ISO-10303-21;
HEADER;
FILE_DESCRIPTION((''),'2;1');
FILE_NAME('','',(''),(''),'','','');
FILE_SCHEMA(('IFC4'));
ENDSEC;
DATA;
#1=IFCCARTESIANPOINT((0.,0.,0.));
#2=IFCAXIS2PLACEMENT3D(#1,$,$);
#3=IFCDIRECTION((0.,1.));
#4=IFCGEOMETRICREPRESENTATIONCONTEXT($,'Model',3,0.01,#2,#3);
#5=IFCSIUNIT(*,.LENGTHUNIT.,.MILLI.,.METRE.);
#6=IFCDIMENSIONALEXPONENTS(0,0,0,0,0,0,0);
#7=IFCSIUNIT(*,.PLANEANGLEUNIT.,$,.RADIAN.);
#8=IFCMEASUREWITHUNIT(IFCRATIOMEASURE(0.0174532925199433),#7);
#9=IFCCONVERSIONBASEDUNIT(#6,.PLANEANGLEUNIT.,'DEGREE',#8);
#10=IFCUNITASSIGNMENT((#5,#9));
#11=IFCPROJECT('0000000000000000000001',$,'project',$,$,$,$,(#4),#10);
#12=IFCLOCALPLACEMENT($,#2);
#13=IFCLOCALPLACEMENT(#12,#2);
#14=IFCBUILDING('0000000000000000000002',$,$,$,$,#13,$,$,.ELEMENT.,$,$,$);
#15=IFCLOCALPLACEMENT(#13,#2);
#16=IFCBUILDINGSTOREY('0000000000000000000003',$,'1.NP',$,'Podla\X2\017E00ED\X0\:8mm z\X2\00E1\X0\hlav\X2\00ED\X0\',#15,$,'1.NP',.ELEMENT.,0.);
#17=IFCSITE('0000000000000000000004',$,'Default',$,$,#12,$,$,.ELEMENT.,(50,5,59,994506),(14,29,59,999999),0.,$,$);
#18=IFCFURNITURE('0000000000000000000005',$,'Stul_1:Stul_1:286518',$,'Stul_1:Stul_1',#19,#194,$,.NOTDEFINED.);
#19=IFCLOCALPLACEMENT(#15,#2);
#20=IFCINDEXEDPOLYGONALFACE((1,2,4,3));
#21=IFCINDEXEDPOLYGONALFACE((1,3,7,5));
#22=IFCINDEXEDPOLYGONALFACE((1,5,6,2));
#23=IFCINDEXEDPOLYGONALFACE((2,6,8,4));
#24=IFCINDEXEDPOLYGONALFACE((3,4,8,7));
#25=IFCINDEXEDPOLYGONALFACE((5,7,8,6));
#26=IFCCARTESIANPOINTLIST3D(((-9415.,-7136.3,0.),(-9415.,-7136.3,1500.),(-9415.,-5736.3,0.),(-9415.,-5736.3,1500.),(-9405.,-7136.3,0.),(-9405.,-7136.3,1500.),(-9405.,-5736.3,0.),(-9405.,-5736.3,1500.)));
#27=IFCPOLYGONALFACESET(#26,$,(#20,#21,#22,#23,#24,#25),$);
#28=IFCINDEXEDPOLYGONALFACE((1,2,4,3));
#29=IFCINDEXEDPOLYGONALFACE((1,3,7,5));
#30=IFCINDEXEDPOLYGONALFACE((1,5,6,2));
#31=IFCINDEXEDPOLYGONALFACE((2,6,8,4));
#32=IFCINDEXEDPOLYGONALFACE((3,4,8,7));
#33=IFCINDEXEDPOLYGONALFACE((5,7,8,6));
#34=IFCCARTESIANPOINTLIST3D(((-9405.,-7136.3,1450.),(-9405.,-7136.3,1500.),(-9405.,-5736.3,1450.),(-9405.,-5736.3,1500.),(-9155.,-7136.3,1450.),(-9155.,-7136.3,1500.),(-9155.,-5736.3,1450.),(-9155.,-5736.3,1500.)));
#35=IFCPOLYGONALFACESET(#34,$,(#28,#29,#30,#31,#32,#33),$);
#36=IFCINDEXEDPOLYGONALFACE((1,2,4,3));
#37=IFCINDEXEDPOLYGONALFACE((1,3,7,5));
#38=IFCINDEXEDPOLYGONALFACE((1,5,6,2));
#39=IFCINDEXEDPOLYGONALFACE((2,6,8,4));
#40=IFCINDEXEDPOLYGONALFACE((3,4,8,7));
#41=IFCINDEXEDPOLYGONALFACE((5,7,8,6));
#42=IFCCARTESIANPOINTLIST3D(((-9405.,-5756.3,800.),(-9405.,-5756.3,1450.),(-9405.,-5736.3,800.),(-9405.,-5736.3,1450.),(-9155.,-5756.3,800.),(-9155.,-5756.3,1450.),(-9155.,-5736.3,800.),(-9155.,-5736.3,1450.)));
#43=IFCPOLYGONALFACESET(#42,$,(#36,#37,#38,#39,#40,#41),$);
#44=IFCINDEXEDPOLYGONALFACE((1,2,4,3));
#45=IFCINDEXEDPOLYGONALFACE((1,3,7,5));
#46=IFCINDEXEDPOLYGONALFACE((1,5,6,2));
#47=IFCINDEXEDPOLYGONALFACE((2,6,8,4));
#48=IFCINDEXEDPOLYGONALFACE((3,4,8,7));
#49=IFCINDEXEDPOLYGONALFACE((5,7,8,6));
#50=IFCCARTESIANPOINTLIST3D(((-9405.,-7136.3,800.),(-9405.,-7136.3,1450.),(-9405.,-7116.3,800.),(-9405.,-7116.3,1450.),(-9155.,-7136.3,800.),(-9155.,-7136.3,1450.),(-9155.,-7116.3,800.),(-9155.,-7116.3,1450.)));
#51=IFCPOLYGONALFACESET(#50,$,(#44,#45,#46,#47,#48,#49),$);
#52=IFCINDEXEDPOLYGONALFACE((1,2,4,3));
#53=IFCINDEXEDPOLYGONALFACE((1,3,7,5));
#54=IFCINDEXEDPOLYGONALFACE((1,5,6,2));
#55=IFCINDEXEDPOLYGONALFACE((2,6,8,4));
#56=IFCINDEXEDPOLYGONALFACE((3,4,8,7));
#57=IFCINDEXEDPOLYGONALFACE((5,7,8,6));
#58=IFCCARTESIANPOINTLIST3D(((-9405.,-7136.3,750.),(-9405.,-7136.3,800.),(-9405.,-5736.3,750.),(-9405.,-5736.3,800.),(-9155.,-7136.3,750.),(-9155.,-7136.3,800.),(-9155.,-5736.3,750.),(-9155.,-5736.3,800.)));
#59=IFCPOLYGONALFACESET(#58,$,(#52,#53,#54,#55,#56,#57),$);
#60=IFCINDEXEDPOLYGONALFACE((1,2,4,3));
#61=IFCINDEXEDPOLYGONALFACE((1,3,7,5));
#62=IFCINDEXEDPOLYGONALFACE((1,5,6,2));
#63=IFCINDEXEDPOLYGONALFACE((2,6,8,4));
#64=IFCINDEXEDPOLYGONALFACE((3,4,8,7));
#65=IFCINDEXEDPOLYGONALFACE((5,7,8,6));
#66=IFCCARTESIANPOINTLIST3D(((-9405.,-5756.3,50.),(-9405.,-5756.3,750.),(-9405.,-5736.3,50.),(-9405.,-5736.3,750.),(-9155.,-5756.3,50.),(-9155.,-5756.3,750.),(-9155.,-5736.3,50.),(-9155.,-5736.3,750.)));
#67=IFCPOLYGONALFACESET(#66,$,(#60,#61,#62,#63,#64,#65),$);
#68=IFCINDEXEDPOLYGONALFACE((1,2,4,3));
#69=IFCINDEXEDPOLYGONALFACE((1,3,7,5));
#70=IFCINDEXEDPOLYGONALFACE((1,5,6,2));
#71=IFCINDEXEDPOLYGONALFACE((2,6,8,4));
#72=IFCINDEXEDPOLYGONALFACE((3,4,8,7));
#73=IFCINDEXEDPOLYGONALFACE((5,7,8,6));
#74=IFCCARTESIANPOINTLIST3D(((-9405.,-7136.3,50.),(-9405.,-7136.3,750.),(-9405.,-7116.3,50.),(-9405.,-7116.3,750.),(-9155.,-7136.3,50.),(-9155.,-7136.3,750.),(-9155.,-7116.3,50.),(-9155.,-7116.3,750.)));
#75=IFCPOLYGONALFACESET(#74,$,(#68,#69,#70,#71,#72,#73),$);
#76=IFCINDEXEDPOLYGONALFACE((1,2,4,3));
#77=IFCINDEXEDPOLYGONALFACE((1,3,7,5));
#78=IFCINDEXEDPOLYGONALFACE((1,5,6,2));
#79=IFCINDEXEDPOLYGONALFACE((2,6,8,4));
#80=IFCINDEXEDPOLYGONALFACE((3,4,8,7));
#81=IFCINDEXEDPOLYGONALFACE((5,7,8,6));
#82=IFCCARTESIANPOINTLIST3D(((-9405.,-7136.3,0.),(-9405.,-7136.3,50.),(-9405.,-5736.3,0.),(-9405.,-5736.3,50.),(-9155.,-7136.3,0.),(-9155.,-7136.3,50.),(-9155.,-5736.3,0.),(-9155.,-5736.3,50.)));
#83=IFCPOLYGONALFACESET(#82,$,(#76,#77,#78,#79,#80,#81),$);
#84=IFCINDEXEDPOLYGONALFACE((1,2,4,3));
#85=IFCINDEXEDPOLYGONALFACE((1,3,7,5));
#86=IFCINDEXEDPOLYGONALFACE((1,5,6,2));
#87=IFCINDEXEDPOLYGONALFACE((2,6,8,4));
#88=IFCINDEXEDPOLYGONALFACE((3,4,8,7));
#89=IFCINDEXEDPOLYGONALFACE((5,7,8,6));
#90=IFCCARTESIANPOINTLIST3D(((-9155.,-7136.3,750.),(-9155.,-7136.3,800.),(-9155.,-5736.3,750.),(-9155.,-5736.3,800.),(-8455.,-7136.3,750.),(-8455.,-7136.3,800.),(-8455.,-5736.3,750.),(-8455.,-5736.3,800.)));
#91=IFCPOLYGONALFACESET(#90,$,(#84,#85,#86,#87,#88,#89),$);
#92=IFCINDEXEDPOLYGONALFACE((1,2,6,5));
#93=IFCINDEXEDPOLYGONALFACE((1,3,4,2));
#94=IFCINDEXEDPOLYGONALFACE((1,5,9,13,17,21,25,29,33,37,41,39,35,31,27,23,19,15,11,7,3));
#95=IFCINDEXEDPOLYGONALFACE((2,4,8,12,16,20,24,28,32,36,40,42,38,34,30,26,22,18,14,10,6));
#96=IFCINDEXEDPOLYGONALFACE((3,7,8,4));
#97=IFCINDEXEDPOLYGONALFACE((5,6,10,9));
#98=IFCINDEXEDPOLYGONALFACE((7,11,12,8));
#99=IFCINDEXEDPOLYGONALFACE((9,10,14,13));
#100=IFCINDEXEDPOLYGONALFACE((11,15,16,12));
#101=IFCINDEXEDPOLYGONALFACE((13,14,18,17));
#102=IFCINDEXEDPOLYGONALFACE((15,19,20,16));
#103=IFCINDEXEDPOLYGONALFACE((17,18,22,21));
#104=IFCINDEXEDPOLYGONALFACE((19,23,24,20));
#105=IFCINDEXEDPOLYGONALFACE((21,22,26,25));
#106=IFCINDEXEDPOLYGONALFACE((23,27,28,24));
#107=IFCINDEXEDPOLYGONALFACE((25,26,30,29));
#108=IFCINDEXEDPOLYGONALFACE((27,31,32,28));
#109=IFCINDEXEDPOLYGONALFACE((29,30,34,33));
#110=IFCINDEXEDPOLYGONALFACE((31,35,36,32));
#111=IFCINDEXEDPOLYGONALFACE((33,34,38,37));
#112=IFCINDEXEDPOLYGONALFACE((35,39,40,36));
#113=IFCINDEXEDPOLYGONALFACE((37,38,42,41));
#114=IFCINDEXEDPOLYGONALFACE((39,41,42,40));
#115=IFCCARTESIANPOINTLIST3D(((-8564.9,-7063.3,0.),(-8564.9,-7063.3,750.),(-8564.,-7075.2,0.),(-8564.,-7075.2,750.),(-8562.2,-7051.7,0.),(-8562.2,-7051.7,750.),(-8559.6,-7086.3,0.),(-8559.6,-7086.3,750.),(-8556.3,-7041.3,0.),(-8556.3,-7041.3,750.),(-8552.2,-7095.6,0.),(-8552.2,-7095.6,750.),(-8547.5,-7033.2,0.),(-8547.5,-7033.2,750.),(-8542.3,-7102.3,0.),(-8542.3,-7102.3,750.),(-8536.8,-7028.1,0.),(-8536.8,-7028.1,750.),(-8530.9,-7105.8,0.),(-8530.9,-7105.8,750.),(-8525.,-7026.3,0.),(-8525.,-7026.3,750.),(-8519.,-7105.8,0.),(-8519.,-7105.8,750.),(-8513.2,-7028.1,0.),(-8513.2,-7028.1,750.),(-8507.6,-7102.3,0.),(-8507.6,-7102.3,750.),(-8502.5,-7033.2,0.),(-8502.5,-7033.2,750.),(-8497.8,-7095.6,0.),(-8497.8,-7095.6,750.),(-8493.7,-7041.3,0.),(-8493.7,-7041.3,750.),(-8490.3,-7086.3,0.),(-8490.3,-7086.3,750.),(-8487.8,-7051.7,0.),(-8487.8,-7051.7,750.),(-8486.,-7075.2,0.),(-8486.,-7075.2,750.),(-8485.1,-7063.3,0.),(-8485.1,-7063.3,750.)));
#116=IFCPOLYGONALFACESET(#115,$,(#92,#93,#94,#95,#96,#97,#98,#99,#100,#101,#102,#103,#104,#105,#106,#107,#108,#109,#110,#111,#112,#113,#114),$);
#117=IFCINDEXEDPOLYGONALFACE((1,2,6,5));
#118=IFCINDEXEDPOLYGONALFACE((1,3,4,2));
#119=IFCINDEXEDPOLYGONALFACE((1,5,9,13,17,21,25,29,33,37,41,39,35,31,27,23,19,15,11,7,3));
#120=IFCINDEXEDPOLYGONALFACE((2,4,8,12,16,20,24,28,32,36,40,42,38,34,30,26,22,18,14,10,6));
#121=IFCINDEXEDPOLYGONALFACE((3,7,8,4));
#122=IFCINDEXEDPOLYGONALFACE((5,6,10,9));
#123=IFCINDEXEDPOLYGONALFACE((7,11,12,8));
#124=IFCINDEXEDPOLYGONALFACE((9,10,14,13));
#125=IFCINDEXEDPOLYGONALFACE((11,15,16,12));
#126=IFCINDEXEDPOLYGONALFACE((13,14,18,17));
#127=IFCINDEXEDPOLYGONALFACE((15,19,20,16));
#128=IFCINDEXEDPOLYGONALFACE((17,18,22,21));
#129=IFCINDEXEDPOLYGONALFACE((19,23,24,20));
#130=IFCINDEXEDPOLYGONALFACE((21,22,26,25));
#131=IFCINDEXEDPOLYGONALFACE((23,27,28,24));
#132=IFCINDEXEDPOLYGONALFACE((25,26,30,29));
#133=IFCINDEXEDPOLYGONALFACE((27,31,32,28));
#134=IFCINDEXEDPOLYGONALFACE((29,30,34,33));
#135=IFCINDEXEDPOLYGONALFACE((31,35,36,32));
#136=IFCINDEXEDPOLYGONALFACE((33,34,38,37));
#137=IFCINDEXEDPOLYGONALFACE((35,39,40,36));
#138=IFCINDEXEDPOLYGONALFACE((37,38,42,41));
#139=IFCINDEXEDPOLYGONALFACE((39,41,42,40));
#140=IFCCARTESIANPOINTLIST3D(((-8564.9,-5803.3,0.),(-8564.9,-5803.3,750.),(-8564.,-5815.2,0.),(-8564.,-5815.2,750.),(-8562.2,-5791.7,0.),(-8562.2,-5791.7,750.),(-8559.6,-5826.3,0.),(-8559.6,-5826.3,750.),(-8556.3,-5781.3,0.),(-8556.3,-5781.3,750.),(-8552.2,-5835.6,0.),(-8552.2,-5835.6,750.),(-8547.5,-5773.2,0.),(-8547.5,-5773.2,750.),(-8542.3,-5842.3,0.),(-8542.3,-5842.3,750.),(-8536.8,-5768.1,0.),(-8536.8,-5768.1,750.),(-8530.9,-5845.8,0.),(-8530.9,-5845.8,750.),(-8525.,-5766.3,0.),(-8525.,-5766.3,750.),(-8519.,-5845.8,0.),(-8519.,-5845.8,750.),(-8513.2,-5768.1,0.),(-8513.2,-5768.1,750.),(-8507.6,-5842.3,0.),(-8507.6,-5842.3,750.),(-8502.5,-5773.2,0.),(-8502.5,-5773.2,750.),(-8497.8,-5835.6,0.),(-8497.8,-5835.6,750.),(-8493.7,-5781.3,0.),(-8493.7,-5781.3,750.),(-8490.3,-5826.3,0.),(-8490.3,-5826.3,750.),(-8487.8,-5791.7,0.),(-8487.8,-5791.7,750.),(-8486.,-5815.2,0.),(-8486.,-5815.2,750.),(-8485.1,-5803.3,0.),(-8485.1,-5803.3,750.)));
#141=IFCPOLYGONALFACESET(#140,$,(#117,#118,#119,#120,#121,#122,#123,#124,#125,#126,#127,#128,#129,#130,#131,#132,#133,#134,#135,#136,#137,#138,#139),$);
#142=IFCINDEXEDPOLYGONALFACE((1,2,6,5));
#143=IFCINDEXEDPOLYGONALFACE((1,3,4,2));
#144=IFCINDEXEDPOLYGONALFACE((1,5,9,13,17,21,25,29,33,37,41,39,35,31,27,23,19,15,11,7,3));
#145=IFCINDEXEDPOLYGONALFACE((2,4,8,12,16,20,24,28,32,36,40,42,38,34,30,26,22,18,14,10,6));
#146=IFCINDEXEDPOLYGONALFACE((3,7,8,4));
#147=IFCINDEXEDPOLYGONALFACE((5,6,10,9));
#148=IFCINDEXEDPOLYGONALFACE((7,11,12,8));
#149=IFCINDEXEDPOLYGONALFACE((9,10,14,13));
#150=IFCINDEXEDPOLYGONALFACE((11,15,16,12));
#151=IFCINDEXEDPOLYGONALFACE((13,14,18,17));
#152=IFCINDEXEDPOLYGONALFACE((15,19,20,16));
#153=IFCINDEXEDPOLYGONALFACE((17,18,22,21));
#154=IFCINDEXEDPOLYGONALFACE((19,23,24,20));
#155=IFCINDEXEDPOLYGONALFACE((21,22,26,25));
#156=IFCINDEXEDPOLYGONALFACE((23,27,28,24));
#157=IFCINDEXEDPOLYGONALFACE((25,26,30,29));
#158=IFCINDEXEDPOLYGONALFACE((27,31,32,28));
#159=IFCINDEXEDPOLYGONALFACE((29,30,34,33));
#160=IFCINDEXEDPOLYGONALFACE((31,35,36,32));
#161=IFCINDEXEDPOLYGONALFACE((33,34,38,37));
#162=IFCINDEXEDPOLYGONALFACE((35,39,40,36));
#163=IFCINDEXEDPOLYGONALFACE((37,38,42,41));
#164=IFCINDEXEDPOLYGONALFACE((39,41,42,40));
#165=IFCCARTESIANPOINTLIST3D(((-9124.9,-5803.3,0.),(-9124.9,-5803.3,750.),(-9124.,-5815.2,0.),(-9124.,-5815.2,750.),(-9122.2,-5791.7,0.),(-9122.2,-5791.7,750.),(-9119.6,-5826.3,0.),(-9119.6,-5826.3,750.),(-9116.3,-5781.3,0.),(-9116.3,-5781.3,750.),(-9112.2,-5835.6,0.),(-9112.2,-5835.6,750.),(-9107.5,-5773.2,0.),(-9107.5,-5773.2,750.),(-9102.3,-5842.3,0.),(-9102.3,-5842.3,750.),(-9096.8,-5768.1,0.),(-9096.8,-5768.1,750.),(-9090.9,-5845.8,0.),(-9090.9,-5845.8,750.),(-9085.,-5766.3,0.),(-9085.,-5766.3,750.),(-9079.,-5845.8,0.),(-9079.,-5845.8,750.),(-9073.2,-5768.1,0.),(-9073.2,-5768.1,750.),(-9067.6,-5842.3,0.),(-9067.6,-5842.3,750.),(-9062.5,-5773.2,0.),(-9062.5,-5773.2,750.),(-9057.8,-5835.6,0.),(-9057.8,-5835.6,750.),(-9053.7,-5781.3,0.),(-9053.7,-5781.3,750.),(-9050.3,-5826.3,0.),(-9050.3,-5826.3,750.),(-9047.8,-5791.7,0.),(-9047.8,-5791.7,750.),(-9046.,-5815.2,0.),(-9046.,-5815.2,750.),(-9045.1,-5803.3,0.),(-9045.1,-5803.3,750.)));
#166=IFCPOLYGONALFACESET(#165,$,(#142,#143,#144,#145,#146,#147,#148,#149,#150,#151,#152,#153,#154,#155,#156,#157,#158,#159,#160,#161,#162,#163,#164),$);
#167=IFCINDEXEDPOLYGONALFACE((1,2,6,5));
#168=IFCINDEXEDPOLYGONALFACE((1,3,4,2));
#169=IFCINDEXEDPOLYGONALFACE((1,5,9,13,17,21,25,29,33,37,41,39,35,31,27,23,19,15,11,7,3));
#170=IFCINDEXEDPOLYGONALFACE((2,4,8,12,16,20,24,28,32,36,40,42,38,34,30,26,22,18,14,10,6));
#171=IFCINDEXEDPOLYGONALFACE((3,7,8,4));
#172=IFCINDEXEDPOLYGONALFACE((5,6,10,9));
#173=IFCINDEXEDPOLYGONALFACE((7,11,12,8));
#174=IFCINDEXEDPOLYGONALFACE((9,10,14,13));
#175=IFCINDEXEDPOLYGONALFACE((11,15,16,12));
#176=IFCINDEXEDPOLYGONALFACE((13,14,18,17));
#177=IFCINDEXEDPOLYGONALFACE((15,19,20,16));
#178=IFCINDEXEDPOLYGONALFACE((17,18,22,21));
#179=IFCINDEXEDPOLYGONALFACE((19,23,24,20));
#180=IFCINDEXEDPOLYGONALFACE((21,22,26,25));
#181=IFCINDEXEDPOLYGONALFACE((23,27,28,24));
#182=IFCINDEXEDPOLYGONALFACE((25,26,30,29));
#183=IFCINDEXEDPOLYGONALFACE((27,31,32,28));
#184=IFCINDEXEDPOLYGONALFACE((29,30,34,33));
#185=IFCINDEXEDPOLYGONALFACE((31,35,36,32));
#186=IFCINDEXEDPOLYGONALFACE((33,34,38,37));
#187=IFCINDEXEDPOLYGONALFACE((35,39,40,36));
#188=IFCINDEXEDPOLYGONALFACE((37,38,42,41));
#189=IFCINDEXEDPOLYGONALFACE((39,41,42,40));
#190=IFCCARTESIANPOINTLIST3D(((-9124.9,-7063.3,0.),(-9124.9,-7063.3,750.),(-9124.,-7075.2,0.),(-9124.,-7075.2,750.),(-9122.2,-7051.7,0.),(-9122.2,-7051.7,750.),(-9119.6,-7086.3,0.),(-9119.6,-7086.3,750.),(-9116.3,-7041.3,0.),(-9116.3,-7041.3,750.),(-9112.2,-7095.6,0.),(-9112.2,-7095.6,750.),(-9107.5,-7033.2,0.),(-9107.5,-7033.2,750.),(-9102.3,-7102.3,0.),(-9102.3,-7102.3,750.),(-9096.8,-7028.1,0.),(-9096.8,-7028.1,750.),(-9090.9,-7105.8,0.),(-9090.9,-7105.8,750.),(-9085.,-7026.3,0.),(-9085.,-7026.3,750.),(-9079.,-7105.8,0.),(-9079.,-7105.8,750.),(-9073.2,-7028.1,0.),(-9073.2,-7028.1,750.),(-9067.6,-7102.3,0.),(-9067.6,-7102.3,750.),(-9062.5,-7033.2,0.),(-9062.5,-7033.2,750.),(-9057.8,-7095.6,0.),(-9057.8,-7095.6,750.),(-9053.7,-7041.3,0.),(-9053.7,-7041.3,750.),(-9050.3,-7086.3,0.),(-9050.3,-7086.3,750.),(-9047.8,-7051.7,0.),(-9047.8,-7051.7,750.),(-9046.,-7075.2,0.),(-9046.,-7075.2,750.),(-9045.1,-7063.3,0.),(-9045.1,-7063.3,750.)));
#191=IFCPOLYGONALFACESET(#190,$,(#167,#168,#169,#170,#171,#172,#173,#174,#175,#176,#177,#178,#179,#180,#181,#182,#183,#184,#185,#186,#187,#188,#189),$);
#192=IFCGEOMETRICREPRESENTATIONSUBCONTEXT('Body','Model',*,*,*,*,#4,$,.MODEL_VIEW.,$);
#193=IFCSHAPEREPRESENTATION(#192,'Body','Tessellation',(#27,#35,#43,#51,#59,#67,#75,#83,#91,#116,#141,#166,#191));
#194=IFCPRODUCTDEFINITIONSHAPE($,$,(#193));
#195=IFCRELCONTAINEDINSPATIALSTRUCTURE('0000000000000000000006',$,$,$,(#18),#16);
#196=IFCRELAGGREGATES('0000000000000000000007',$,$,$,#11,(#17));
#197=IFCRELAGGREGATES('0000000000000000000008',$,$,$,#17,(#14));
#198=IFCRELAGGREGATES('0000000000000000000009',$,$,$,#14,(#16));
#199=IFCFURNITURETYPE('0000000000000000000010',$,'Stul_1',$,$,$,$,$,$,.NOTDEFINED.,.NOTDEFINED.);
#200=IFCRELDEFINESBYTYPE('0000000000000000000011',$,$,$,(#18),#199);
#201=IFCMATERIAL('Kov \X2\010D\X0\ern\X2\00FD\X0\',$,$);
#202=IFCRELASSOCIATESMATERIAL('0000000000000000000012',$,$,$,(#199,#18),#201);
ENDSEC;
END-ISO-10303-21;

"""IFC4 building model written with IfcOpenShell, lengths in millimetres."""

from ifc_helpers import new_model, entity, si_unit, converted_unit, direction, frame, frame_2d, origin, origin_2d_with_axis, place, context, subcontext, project, spatial, rectangle, circle, extrude, source, transform, mapped, material, type_object, type_shapes, element, save


model = new_model("IFC4")

# Units and contexts
model_context = context("Model", 3, precision=0.01, world=origin(), true_north=direction((0.0, 1.0)))
body_context = subcontext(model_context, "Body", "Model", "MODEL_VIEW")
ifc_project = project(units=[si_unit("LENGTHUNIT", "METRE", prefix="MILLI"), converted_unit("PLANEANGLEUNIT", "DEGREE", entity("IfcRatioMeasure", 0.0174532925199433), si_unit("PLANEANGLEUNIT", "RADIAN"), dimensions=[0, 0, 0, 0, 0, 0, 0])], contexts=[model_context])

# Site, building, storey
site_placement = place(None, origin())
site = spatial("IfcSite", under=ifc_project, at=site_placement, Name="Default", CompositionType="ELEMENT", RefLatitude=(50, 5, 59, 994506), RefLongitude=(14, 29, 59, 999999), RefElevation=0.0)
building_placement = place(site_placement, origin())
building = spatial("IfcBuilding", under=site, at=building_placement, CompositionType="ELEMENT")
storey_placement = place(building_placement, origin())
storey = spatial("IfcBuildingStorey", under=building, at=storey_placement, Name="1.NP", ObjectType="Podlaží:8mm záhlaví", LongName="1.NP", CompositionType="ELEMENT", Elevation=0.0)

# Furniture
ifc_material_1 = material(Name="Kov černý")
furniture_type = type_object("IfcFurnitureType", Name="Stul_1", AssemblyPlace="NOTDEFINED", PredefinedType="NOTDEFINED", material=ifc_material_1)
shared_shape_1 = source(origin(), body_context, "Body", "SweptSolid", [
    extrude(rectangle(XDim=1400.0, YDim=10.0, at=origin_2d_with_axis()), frame((0.0, 605.0, 0.0), z_axis=(0.0, 0.0, 1.0), x_axis=(-1.0, 0.0, 0.0)), (0.0, 0.0, 1.0), 1500.0),
    extrude(rectangle(XDim=1400.0, YDim=250.0, at=frame_2d((0.0, 0.0), x_axis=(1.0, 0.0))), frame((0.0, 475.0, 1450.0), z_axis=(0.0, 0.0, 1.0), x_axis=(-1.0, 0.0, 0.0)), (0.0, 0.0, 1.0), 50.0),
    extrude(rectangle(XDim=20.0, YDim=250.0, at=origin_2d_with_axis()), frame((690.0, 475.0, 800.0), z_axis=(0.0, 0.0, 1.0), x_axis=(-1.0, 0.0, 0.0)), (0.0, 0.0, 1.0), 650.0),
    extrude(rectangle(XDim=20.0, YDim=250.0, at=frame_2d((0.0, 0.0), x_axis=(1.0, 0.0))), frame((-690.0, 475.0, 800.0), z_axis=(0.0, 0.0, 1.0), x_axis=(-1.0, 0.0, 0.0)), (0.0, 0.0, 1.0), 650.0),
    extrude(rectangle(XDim=1400.0, YDim=250.0, at=origin_2d_with_axis()), frame((0.0, 475.0, 750.0), z_axis=(0.0, 0.0, 1.0), x_axis=(-1.0, 0.0, 0.0)), (0.0, 0.0, 1.0), 50.0),
    extrude(rectangle(XDim=20.0, YDim=250.0, at=origin_2d_with_axis()), frame((690.0, 475.0, 50.0), z_axis=(0.0, 0.0, 1.0), x_axis=(-1.0, 0.0, 0.0)), (0.0, 0.0, 1.0), 700.0),
    extrude(rectangle(XDim=20.0, YDim=250.0, at=frame_2d((0.0, 0.0), x_axis=(1.0, 0.0))), frame((-690.0, 475.0, 50.0), z_axis=(0.0, 0.0, 1.0), x_axis=(-1.0, 0.0, 0.0)), (0.0, 0.0, 1.0), 700.0),
    extrude(rectangle(XDim=1400.0, YDim=250.0, at=origin_2d_with_axis()), frame((0.0, 475.0, 0.0), z_axis=(0.0, 0.0, 1.0), x_axis=(-1.0, 0.0, 0.0)), (0.0, 0.0, 1.0), 50.0),
    extrude(rectangle(XDim=1400.0, YDim=700.0, at=origin_2d_with_axis()), frame((0.0, 0.0, 750.0), z_axis=(0.0, 0.0, 1.0), x_axis=(-1.0, 0.0, 0.0)), (0.0, 0.0, 1.0), 50.0),
    extrude(circle(Radius=40.0, at=frame_2d((0.0, 0.0), x_axis=(1.0, 0.0))), frame((-630.0, -280.0, 0.0)), (0.0, 0.0, 1.0), 750.0),
    extrude(circle(Radius=40.0, at=frame_2d((0.0, 0.0), x_axis=(1.0, 0.0))), frame((630.0, -280.0, 0.0)), (0.0, 0.0, 1.0), 750.0),
    extrude(circle(Radius=40.0, at=frame_2d((0.0, 0.0), x_axis=(1.0, 0.0))), frame((630.0, 280.0, 0.0)), (0.0, 0.0, 1.0), 750.0),
    extrude(circle(Radius=40.0, at=frame_2d((0.0, 0.0), x_axis=(1.0, 0.0))), frame((-630.0, 280.0, 0.0)), (0.0, 0.0, 1.0), 750.0),
])
type_shapes(furniture_type, [shared_shape_1])
for number, where, z_axis, x_axis, name in (
    (1, (-8805.0, -6436.3, 0.0), (0.0, 0.0, 1.0), (0.0, 1.0, 0.0), "Stul_1:Stul_1:286518"),
):
    element("IfcFurniture", number, at=place(storey_placement, frame(where, z_axis=z_axis, x_axis=x_axis)), inside=storey, type_object=furniture_type, material=ifc_material_1, Name=name, ObjectType="Stul_1:Stul_1", PredefinedType="NOTDEFINED", context=body_context, shape_type="MappedRepresentation", body=[
        mapped(shared_shape_1, transform((0.0, 0.0, 0.0), scale=1.0)),
    ])

save(model, "model.ifc")
